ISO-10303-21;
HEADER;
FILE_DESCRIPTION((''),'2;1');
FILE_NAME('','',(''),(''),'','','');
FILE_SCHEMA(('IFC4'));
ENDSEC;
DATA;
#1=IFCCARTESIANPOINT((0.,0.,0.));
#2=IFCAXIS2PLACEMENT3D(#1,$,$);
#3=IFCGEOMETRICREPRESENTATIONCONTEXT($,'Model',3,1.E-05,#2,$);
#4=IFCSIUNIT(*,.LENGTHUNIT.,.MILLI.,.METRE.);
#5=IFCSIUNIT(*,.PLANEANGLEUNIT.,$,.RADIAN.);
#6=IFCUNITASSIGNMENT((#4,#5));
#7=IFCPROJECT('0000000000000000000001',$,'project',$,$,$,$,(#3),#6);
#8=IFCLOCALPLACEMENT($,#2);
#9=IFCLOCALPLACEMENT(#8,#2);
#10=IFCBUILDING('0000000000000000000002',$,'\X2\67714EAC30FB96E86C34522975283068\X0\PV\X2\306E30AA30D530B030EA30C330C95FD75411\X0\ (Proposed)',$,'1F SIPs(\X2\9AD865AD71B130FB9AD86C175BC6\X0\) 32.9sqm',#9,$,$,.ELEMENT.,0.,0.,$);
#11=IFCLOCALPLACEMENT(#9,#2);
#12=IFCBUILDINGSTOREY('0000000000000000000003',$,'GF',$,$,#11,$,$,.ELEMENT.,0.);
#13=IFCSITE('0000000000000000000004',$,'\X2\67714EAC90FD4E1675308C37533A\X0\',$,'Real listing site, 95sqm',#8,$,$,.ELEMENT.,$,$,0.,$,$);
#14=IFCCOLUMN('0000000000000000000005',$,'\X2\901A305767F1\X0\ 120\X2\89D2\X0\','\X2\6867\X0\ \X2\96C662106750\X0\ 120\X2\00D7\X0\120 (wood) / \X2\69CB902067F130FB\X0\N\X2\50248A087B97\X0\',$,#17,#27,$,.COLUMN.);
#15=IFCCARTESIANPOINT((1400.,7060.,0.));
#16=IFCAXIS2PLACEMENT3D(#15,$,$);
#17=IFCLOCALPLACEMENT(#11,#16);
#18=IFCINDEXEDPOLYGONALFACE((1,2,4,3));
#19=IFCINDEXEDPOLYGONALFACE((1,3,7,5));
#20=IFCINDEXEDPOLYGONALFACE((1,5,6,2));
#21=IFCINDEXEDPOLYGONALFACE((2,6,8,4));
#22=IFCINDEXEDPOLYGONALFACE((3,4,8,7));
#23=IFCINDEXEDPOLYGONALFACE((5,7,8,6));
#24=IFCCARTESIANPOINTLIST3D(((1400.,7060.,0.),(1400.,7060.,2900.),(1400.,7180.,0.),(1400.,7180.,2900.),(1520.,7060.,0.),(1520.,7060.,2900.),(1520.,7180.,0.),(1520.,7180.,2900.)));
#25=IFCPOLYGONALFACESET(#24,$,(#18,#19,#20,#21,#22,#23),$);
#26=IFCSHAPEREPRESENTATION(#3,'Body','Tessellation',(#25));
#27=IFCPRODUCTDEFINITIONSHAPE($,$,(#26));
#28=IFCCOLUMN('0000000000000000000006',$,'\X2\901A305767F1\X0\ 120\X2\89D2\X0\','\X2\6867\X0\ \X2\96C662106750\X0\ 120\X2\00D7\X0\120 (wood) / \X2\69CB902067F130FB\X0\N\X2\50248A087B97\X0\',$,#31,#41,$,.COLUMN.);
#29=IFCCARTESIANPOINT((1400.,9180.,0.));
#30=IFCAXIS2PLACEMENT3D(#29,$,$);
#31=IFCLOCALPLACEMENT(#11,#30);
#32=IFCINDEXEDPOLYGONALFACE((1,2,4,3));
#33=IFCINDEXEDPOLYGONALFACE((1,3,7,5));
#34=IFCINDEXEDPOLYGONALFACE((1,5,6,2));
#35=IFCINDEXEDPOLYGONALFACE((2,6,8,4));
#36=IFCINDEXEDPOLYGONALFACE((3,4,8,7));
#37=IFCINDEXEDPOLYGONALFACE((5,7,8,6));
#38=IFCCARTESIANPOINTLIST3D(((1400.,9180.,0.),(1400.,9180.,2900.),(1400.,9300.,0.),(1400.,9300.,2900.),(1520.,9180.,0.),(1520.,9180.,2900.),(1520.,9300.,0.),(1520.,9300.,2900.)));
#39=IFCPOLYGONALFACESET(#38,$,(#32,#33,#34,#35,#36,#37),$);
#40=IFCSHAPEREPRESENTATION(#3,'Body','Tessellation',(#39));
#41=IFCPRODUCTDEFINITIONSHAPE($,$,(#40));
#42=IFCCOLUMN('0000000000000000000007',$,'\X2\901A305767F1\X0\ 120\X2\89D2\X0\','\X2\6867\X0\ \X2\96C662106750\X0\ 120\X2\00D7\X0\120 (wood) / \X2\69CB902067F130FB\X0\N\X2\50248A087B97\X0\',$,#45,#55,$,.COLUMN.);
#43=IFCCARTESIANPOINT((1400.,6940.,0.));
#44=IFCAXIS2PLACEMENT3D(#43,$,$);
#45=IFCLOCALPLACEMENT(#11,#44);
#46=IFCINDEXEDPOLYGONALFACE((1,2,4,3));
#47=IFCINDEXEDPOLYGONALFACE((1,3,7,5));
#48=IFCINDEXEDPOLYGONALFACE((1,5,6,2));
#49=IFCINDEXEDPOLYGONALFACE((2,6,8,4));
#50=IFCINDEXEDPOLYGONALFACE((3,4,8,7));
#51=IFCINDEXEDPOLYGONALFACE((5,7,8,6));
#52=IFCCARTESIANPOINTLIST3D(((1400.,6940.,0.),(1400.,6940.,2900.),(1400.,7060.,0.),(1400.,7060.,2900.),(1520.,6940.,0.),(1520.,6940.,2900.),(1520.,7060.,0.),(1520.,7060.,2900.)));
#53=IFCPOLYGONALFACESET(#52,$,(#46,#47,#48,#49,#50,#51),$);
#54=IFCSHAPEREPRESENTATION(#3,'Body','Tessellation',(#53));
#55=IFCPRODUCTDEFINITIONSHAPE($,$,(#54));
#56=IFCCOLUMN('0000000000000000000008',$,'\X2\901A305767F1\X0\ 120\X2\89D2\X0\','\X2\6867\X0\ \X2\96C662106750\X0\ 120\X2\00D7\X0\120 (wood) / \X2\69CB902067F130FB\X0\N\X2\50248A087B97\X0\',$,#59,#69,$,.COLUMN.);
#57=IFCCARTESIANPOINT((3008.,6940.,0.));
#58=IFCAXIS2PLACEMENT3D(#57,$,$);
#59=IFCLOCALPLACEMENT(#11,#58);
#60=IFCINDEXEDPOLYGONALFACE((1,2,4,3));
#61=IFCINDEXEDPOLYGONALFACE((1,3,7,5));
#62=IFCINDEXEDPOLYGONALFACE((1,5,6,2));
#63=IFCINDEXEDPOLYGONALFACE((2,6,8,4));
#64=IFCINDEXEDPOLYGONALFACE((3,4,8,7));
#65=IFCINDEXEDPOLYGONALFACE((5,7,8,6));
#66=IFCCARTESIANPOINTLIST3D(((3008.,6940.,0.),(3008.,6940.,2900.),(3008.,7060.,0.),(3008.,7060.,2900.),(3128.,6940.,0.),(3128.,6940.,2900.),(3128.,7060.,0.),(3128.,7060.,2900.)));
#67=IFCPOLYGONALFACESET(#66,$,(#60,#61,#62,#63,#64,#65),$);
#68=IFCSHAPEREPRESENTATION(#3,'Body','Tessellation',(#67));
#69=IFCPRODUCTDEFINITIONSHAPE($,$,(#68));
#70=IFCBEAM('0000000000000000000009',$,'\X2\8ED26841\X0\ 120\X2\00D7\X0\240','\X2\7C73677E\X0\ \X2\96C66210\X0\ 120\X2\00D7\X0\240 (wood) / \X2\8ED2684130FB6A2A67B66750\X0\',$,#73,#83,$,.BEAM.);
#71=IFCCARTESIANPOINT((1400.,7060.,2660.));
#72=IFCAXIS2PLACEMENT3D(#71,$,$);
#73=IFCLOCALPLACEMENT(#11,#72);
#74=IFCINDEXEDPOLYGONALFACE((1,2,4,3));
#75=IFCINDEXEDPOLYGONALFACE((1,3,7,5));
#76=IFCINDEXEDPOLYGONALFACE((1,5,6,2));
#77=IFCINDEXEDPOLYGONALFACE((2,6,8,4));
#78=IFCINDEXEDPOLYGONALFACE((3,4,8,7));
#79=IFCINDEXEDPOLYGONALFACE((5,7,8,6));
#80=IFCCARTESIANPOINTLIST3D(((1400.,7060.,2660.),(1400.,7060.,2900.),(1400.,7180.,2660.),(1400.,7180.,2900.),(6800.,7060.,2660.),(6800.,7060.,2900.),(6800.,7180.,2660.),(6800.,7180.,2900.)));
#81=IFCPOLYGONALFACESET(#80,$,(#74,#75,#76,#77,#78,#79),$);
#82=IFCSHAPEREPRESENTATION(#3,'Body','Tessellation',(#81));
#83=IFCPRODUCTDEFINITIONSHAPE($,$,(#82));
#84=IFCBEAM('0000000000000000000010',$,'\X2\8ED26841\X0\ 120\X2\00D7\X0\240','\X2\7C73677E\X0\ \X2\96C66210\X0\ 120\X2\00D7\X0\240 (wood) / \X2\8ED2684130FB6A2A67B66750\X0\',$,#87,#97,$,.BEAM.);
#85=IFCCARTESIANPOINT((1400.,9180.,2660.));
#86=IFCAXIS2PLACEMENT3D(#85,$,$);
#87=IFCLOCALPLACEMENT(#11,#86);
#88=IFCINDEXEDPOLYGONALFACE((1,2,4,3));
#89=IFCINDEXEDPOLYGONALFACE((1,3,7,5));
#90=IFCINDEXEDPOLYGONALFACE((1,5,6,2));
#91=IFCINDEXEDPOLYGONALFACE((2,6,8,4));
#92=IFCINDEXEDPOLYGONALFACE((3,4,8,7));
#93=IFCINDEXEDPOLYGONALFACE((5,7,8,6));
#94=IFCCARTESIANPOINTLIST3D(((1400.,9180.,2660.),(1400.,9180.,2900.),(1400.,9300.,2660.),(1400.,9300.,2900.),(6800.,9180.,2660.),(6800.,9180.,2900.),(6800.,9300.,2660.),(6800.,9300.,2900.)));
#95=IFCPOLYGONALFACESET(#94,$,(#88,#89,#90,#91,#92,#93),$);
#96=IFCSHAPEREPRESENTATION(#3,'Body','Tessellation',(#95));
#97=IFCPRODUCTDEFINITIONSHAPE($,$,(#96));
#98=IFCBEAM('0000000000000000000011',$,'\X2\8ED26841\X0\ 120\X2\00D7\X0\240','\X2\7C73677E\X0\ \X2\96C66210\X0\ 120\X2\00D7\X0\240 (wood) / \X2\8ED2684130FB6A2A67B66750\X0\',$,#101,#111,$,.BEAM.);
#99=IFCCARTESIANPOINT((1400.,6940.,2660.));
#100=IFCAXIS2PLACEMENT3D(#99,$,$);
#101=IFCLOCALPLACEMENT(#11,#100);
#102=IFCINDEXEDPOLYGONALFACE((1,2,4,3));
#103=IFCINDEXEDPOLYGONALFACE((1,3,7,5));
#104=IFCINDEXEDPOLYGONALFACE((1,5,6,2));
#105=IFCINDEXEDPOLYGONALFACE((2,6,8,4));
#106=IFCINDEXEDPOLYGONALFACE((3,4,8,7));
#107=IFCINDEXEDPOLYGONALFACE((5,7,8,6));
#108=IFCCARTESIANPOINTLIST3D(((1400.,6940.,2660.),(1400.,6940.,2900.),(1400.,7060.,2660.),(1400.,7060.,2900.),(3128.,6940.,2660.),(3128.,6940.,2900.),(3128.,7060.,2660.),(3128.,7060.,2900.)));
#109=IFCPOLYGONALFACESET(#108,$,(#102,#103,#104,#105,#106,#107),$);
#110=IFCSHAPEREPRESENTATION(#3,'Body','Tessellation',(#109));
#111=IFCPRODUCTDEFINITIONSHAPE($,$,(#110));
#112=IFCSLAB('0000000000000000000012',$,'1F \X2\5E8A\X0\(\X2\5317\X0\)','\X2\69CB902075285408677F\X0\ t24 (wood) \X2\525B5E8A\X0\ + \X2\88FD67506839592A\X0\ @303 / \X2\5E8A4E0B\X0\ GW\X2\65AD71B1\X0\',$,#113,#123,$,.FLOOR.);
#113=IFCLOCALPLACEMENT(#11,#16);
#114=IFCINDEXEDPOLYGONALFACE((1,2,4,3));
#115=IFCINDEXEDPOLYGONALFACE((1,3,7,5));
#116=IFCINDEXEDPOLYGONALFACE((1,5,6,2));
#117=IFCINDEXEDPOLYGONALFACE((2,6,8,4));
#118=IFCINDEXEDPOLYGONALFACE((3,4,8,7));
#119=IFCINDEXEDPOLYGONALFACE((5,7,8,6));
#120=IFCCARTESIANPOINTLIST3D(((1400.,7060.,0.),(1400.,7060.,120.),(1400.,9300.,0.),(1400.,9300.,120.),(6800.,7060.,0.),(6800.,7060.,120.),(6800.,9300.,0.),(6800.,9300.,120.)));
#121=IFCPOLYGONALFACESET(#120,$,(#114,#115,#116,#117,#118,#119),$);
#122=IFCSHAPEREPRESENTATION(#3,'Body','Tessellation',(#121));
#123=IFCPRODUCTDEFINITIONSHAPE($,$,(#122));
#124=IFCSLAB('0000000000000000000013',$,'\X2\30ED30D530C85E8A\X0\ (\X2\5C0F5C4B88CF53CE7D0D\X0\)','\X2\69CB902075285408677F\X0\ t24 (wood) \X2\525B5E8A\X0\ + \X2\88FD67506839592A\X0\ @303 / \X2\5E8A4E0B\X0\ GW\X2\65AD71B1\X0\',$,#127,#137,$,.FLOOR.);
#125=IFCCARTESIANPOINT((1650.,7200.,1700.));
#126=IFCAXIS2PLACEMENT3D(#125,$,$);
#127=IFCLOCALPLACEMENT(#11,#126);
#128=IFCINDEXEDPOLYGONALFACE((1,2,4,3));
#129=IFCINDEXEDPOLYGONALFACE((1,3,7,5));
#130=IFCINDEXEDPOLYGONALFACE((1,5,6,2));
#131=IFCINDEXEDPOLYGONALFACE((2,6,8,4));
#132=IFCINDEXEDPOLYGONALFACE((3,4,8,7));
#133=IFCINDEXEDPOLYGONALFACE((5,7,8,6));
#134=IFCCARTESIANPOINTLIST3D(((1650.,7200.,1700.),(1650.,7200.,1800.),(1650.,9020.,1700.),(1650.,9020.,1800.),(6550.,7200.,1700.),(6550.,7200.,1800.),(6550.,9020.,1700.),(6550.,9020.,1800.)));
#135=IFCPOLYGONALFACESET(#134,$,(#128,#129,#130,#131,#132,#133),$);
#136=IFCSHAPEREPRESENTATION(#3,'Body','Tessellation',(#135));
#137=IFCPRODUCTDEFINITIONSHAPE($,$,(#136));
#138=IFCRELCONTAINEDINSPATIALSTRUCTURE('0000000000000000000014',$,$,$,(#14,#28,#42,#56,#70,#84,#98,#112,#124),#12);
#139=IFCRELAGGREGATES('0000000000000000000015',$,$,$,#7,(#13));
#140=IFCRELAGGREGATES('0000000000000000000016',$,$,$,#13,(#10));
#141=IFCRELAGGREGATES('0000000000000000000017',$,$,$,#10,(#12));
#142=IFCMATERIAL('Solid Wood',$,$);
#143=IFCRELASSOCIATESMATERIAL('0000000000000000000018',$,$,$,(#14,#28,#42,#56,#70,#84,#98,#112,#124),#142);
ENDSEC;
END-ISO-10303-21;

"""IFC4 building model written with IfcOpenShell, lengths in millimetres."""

from ifc_helpers import new_model, si_unit, frame, frame_2d, origin, place, context, project, spatial, rectangle, extrude, material, element, save


model = new_model("IFC4")

# Units and contexts
model_context = context("Model", 3, precision=1e-05, world=origin())
ifc_project = project(units=[si_unit("LENGTHUNIT", "METRE", prefix="MILLI"), si_unit("PLANEANGLEUNIT", "RADIAN")], contexts=[model_context])

# Site, building, storey
site_placement = place(None, origin())
site = spatial("IfcSite", under=ifc_project, at=site_placement, Name="東京都世田谷区", ObjectType="Real listing site, 95sqm", CompositionType="ELEMENT", RefElevation=0.0)
building_placement = place(site_placement, origin())
building = spatial("IfcBuilding", under=site, at=building_placement, Name="東京・雨水利用とPVのオフグリッド志向 (Proposed)", ObjectType="1F SIPs(高断熱・高気密) 32.9sqm", CompositionType="ELEMENT", ElevationOfRefHeight=0.0, ElevationOfTerrain=0.0)
storey_placement = place(building_placement, origin())
storey = spatial("IfcBuildingStorey", under=building, at=storey_placement, Name="GF", CompositionType="ELEMENT", Elevation=0.0)

# Columns
ifc_material_1 = material(Name="Solid Wood")
column_1_placement = place(storey_placement, frame((1400.0, 7060.0, 0.0)))
element("IfcColumn", 1, at=column_1_placement, inside=storey, material=ifc_material_1, Name="通し柱 120角", Description="桧 集成材 120×120 (wood) / 構造柱・N値計算", PredefinedType="COLUMN", context=model_context, shape_type="SweptSolid", body=[
    extrude(rectangle(XDim=120.0, YDim=120.0, at=frame_2d((60.0, 60.0))), frame((1400.0, 7060.0, 0.0)), (0.0, 0.0, 1.0), 2900.0),
])
column_2_placement = place(storey_placement, frame((1400.0, 9180.0, 0.0)))
element("IfcColumn", 2, at=column_2_placement, inside=storey, material=ifc_material_1, Name="通し柱 120角", Description="桧 集成材 120×120 (wood) / 構造柱・N値計算", PredefinedType="COLUMN", context=model_context, shape_type="SweptSolid", body=[
    extrude(rectangle(XDim=120.0, YDim=120.0, at=frame_2d((60.0, 60.0))), frame((1400.0, 9180.0, 0.0)), (0.0, 0.0, 1.0), 2900.0),
])
column_3_placement = place(storey_placement, frame((1400.0, 6940.0, 0.0)))
element("IfcColumn", 3, at=column_3_placement, inside=storey, material=ifc_material_1, Name="通し柱 120角", Description="桧 集成材 120×120 (wood) / 構造柱・N値計算", PredefinedType="COLUMN", context=model_context, shape_type="SweptSolid", body=[
    extrude(rectangle(XDim=120.0, YDim=120.0, at=frame_2d((60.0, 60.0))), frame((1400.0, 6940.0, 0.0)), (0.0, 0.0, 1.0), 2900.0),
])
column_4_placement = place(storey_placement, frame((3008.0, 6940.0, 0.0)))
element("IfcColumn", 4, at=column_4_placement, inside=storey, material=ifc_material_1, Name="通し柱 120角", Description="桧 集成材 120×120 (wood) / 構造柱・N値計算", PredefinedType="COLUMN", context=model_context, shape_type="SweptSolid", body=[
    extrude(rectangle(XDim=120.0, YDim=120.0, at=frame_2d((60.0, 60.0))), frame((3008.0, 6940.0, 0.0)), (0.0, 0.0, 1.0), 2900.0),
])

# Beams
beam_1_placement = place(storey_placement, frame((1400.0, 7060.0, 2660.0)))
element("IfcBeam", 5, at=beam_1_placement, inside=storey, material=ifc_material_1, Name="軒桁 120×240", Description="米松 集成 120×240 (wood) / 軒桁・横架材", PredefinedType="BEAM", context=model_context, shape_type="SweptSolid", body=[
    extrude(rectangle(XDim=5400.0, YDim=120.0, at=frame_2d((2700.0, 60.0))), frame((1400.0, 7060.0, 2660.0)), (0.0, 0.0, 1.0), 240.0),
])
beam_2_placement = place(storey_placement, frame((1400.0, 9180.0, 2660.0)))
element("IfcBeam", 6, at=beam_2_placement, inside=storey, material=ifc_material_1, Name="軒桁 120×240", Description="米松 集成 120×240 (wood) / 軒桁・横架材", PredefinedType="BEAM", context=model_context, shape_type="SweptSolid", body=[
    extrude(rectangle(XDim=5400.0, YDim=120.0, at=frame_2d((2700.0, 60.0))), frame((1400.0, 9180.0, 2660.0)), (0.0, 0.0, 1.0), 240.0),
])
beam_3_placement = place(storey_placement, frame((1400.0, 6940.0, 2660.0)))
element("IfcBeam", 7, at=beam_3_placement, inside=storey, material=ifc_material_1, Name="軒桁 120×240", Description="米松 集成 120×240 (wood) / 軒桁・横架材", PredefinedType="BEAM", context=model_context, shape_type="SweptSolid", body=[
    extrude(rectangle(XDim=1728.0, YDim=120.0, at=frame_2d((864.0, 60.0))), frame((1400.0, 6940.0, 2660.0)), (0.0, 0.0, 1.0), 240.0),
])

# Slabs
slab_1_placement = place(storey_placement, frame((1400.0, 7060.0, 0.0)))
element("IfcSlab", 8, at=slab_1_placement, inside=storey, material=ifc_material_1, Name="1F 床(北)", Description="構造用合板 t24 (wood) 剛床 + 製材根太 @303 / 床下 GW断熱", PredefinedType="FLOOR", context=model_context, shape_type="SweptSolid", body=[
    extrude(rectangle(XDim=5400.0, YDim=2240.0, at=frame_2d((2700.0, 1120.0))), frame((1400.0, 7060.0, 0.0)), (0.0, 0.0, 1.0), 120.0),
])
slab_2_placement = place(storey_placement, frame((1650.0, 7200.0, 1700.0)))
element("IfcSlab", 9, at=slab_2_placement, inside=storey, material=ifc_material_1, Name="ロフト床 (小屋裏収納)", Description="構造用合板 t24 (wood) 剛床 + 製材根太 @303 / 床下 GW断熱", PredefinedType="FLOOR", context=model_context, shape_type="SweptSolid", body=[
    extrude(rectangle(XDim=4900.0, YDim=1820.0, at=frame_2d((2450.0, 910.0))), frame((1650.0, 7200.0, 1700.0)), (0.0, 0.0, 1.0), 100.0),
])

save(model, "model.ifc")
